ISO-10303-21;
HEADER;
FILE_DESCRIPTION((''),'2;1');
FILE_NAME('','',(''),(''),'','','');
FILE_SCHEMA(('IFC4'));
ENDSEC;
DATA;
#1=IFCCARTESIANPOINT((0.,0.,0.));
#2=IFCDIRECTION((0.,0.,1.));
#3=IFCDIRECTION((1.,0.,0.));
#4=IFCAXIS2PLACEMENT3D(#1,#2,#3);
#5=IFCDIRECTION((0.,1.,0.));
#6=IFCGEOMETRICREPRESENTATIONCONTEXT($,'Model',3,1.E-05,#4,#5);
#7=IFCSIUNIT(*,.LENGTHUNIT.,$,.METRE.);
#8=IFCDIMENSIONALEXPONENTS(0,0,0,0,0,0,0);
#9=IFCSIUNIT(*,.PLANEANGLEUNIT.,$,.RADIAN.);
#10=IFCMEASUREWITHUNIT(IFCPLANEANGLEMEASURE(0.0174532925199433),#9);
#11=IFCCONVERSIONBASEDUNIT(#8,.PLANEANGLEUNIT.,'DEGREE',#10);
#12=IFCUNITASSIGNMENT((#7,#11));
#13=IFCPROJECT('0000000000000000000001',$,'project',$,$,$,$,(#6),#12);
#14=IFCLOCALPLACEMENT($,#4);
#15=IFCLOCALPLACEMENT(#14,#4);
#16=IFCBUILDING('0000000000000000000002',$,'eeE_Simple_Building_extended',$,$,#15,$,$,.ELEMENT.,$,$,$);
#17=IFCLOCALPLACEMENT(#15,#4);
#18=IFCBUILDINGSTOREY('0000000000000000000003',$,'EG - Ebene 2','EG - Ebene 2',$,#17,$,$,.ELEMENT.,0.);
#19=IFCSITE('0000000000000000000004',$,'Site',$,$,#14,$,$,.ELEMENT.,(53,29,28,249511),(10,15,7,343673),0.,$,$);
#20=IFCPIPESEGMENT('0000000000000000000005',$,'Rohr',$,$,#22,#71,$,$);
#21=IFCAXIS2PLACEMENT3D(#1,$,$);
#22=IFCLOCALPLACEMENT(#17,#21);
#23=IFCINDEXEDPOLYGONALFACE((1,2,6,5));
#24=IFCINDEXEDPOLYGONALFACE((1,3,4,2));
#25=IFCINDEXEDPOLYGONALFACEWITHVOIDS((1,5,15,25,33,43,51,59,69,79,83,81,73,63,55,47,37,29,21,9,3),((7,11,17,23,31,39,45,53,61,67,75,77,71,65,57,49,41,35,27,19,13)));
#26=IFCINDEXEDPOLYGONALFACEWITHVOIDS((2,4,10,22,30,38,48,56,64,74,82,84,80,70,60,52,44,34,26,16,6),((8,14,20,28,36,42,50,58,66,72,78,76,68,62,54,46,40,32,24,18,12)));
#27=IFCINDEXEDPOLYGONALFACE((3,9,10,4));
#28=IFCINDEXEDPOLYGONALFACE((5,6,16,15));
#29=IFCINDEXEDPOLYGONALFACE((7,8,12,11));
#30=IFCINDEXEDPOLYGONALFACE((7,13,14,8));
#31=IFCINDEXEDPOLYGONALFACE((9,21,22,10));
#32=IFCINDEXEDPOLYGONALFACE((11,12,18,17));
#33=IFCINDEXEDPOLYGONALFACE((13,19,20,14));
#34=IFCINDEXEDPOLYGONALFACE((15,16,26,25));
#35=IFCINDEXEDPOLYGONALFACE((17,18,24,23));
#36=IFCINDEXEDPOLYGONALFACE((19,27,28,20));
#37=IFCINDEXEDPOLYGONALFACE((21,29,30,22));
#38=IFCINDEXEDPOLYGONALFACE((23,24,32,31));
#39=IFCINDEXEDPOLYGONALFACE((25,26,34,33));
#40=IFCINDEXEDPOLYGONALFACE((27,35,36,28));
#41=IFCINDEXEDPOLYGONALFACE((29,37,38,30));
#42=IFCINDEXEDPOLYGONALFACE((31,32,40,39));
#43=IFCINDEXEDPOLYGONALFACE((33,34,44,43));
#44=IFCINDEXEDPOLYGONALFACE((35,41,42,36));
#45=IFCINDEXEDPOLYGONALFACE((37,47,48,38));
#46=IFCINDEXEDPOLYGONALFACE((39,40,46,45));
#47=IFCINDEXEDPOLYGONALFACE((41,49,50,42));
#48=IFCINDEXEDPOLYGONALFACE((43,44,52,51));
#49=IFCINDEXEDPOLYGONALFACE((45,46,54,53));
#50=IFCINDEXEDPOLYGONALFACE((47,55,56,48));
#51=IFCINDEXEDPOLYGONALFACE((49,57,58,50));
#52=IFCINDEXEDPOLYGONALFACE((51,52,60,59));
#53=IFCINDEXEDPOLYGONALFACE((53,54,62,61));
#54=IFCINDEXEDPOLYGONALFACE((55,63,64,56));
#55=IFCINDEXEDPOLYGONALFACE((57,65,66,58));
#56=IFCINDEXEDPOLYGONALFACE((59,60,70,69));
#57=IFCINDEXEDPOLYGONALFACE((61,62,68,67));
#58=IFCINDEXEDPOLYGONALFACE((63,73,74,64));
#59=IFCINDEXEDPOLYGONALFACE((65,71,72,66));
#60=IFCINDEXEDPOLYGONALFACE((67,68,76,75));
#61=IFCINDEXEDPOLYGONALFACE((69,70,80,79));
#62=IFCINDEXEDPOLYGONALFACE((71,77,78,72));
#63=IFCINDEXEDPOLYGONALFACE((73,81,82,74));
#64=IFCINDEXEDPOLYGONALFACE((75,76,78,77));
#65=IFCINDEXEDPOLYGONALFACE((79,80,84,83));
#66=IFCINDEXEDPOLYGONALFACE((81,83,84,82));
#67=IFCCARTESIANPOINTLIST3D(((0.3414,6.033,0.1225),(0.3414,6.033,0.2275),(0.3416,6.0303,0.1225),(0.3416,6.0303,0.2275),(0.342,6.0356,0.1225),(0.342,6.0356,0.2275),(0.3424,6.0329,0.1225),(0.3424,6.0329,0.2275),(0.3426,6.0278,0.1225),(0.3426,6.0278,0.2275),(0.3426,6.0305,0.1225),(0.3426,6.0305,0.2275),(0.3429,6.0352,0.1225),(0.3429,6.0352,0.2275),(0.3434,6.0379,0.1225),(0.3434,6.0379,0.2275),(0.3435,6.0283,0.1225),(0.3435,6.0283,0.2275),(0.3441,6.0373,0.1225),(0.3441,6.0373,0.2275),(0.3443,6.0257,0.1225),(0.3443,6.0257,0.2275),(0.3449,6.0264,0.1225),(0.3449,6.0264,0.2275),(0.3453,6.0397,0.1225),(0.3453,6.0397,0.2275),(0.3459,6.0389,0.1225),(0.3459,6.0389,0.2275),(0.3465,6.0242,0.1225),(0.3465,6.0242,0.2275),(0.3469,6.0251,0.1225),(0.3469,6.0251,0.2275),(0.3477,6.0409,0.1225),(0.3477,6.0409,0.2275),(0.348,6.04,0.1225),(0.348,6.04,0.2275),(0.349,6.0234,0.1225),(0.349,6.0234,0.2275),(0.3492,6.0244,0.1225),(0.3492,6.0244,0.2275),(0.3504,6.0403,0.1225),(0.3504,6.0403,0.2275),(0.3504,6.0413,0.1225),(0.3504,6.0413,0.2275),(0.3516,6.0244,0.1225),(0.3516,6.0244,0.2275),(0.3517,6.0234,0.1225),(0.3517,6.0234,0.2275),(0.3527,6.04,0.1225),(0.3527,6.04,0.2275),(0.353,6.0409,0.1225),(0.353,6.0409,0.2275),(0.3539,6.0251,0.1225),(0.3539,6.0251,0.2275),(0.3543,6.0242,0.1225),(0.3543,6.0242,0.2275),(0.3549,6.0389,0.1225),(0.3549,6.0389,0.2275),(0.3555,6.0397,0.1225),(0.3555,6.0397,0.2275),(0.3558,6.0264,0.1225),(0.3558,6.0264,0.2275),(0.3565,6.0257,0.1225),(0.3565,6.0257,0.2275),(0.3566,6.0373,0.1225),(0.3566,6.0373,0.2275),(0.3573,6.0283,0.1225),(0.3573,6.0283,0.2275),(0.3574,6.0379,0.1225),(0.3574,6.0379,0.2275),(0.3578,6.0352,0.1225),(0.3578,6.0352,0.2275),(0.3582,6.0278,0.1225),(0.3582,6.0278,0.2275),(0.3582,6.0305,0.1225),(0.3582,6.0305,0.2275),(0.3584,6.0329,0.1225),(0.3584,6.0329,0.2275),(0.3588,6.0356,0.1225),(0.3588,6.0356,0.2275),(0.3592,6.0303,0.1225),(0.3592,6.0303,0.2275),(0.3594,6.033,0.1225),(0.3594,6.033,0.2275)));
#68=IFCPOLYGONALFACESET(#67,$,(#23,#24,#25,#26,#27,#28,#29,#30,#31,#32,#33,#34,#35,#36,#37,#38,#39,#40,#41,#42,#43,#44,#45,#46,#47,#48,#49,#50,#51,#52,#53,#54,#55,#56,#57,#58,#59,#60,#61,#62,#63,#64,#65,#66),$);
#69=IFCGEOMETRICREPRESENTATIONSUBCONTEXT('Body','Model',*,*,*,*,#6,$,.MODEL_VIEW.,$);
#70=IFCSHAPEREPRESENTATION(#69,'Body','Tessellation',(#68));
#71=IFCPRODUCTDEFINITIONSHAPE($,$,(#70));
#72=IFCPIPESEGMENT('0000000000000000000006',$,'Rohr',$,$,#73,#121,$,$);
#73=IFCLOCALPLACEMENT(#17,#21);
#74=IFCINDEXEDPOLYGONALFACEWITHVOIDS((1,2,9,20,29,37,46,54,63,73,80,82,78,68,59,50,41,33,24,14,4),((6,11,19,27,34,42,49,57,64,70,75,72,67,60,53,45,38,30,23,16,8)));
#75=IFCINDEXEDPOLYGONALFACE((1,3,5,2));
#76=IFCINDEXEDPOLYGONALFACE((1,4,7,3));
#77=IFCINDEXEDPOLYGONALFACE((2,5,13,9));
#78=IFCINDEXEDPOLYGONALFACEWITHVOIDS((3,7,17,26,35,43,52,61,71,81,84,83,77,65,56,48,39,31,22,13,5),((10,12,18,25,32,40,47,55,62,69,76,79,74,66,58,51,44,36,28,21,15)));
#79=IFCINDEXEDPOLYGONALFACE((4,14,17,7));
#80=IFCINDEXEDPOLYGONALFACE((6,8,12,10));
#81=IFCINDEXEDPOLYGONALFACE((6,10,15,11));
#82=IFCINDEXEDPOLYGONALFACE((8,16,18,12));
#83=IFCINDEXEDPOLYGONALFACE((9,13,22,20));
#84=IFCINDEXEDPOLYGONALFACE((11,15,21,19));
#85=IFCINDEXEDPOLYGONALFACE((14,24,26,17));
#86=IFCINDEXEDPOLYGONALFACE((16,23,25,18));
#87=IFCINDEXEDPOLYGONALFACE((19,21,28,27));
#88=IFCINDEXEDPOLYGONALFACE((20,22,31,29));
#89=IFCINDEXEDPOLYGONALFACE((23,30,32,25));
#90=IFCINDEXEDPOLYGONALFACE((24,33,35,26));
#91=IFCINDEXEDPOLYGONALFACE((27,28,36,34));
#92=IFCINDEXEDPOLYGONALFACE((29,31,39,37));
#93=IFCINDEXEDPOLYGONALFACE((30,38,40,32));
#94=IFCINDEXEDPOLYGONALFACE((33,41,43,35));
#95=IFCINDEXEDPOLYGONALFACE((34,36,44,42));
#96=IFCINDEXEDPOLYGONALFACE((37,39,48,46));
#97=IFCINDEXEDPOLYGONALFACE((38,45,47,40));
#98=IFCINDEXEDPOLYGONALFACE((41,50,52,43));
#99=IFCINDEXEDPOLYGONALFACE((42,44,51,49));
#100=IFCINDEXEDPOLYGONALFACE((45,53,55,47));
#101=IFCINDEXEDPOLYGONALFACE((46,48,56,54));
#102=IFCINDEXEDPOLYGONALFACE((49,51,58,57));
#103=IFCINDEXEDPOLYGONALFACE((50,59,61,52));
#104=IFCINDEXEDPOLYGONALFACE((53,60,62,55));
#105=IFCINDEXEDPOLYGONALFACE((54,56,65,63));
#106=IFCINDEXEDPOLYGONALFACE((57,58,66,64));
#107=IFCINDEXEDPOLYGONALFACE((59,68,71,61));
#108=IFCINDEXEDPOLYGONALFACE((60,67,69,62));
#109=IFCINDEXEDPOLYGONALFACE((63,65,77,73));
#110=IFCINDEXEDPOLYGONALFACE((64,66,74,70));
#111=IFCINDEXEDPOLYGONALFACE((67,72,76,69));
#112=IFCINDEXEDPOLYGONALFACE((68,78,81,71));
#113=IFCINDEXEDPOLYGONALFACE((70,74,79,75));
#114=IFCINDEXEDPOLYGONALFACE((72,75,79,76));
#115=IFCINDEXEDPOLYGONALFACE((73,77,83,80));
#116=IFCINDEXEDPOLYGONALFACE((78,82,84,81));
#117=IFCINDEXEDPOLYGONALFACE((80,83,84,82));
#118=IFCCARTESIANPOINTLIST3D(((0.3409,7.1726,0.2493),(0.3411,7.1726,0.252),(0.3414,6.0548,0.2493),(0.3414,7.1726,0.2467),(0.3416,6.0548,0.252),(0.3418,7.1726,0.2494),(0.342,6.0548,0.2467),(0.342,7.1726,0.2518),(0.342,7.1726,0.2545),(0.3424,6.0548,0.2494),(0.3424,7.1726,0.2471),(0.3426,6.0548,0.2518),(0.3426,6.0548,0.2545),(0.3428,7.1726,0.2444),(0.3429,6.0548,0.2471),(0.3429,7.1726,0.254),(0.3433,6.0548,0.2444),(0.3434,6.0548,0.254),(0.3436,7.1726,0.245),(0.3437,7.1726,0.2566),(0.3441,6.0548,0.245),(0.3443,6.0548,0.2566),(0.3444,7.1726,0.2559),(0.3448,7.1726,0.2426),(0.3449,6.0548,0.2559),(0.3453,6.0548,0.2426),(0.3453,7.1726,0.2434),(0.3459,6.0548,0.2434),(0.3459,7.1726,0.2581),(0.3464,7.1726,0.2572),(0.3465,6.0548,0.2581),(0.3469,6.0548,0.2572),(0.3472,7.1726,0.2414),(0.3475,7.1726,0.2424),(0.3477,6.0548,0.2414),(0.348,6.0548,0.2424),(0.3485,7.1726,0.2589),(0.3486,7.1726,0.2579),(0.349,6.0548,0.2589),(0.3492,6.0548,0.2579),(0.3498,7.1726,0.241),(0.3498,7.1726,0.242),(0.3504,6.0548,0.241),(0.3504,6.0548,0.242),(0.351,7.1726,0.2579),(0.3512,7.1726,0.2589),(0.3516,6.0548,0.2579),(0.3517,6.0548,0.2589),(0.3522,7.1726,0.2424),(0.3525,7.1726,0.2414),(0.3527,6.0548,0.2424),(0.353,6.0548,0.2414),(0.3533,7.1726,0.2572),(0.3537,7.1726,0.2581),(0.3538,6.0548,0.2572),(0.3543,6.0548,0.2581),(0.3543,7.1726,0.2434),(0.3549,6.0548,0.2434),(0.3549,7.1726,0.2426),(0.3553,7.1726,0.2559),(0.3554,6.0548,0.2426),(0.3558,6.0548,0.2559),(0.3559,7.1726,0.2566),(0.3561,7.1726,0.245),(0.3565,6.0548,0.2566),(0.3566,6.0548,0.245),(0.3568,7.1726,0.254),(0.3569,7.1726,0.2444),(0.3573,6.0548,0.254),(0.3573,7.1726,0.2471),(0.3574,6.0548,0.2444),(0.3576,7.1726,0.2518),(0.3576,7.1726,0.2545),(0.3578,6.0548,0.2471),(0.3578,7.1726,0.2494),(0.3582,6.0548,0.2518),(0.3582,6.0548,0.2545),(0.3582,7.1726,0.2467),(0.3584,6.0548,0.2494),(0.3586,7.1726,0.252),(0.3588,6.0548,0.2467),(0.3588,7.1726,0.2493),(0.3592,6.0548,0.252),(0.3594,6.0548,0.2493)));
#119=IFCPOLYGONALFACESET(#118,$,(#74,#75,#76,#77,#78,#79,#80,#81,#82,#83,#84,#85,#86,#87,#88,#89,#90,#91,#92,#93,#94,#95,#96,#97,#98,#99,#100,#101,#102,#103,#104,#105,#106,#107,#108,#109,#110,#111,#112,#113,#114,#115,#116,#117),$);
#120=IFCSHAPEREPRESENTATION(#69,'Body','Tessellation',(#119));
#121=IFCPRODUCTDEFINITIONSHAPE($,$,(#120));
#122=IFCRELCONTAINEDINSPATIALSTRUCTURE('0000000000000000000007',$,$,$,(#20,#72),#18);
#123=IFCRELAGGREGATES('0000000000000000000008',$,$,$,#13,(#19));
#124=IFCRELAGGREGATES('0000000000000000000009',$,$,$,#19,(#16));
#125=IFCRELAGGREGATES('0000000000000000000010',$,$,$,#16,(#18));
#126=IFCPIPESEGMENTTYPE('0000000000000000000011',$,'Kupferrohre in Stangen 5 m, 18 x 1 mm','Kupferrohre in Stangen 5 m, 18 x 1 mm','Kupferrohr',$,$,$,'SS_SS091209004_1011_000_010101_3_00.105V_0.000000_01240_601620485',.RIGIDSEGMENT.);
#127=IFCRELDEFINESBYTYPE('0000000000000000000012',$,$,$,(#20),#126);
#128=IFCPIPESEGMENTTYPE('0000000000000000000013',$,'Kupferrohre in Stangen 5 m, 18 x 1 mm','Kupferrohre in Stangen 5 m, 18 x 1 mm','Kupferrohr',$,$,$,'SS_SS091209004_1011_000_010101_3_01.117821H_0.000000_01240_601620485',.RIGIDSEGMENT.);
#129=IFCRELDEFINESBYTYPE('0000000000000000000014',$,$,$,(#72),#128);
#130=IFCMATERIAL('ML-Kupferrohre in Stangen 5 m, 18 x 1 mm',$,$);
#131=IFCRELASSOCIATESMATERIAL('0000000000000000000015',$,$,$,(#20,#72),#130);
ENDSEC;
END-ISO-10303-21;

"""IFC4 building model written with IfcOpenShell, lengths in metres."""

from ifc_helpers import new_model, entity, si_unit, converted_unit, direction, frame, origin_with_axes, origin_2d_with_axis, place, context, subcontext, project, spatial, hollow_circle, extrude, material, type_object, element, save


model = new_model("IFC4")

# Units and contexts
model_context = context("Model", 3, precision=1e-05, world=origin_with_axes(), true_north=direction((0.0, 1.0, 0.0)))
body_context = subcontext(model_context, "Body", "Model", "MODEL_VIEW")
ifc_project = project(units=[si_unit("LENGTHUNIT", "METRE"), converted_unit("PLANEANGLEUNIT", "DEGREE", entity("IfcPlaneAngleMeasure", 0.0174532925199433), si_unit("PLANEANGLEUNIT", "RADIAN"), dimensions=[0, 0, 0, 0, 0, 0, 0])], contexts=[model_context])

# Site, building, storey
site_placement = place(None, origin_with_axes())
site = spatial("IfcSite", under=ifc_project, at=site_placement, Name="Site", CompositionType="ELEMENT", RefLatitude=(53, 29, 28, 249511), RefLongitude=(10, 15, 7, 343673), RefElevation=0.0)
building_placement = place(site_placement, origin_with_axes())
building = spatial("IfcBuilding", under=site, at=building_placement, Name="eeE_Simple_Building_extended", CompositionType="ELEMENT")
storey_placement = place(building_placement, origin_with_axes())
storey = spatial("IfcBuildingStorey", under=building, at=storey_placement, Name="EG - Ebene 2", Description="EG - Ebene 2", CompositionType="ELEMENT", Elevation=0.0)

# Pipe segments
ifc_material_1 = material(Name="ML-Kupferrohre in Stangen 5 m, 18 x 1 mm")
pipe_segment_type_1 = type_object("IfcPipeSegmentType", Name="Kupferrohre in Stangen 5 m, 18 x 1 mm", Description="Kupferrohre in Stangen 5 m, 18 x 1 mm", ApplicableOccurrence="Kupferrohr", ElementType="SS_SS091209004_1011_000_010101_3_00.105V_0.000000_01240_601620485", PredefinedType="RIGIDSEGMENT")
pipe_segment_1_placement = place(storey_placement, frame((0.3504, 6.0323, 0.1225), z_axis=(0.0, -1.0, 0.0), x_axis=(0.0, 0.0, 1.0)))
element("IfcPipeSegment", 1, at=pipe_segment_1_placement, inside=storey, type_object=pipe_segment_type_1, material=ifc_material_1, Name="Rohr", context=body_context, shape_type="SweptSolid", body=[
    extrude(hollow_circle(Radius=0.009, WallThickness=0.001, at=origin_2d_with_axis()), frame((0.0, 0.0, 0.0), z_axis=(1.0, 0.0, 0.0), x_axis=(0.0, 0.0, -1.0)), (0.0, 0.0, 1.0), 0.105),
])
pipe_segment_type_2 = type_object("IfcPipeSegmentType", Name="Kupferrohre in Stangen 5 m, 18 x 1 mm", Description="Kupferrohre in Stangen 5 m, 18 x 1 mm", ApplicableOccurrence="Kupferrohr", ElementType="SS_SS091209004_1011_000_010101_3_01.117821H_0.000000_01240_601620485", PredefinedType="RIGIDSEGMENT")
pipe_segment_2_placement = place(storey_placement, frame((0.3504, 6.0548, 0.25), z_axis=(0.0, 0.0, 1.0), x_axis=(-0.000492, 1.0, 0.0)))
element("IfcPipeSegment", 2, at=pipe_segment_2_placement, inside=storey, type_object=pipe_segment_type_2, material=ifc_material_1, Name="Rohr", context=body_context, shape_type="SweptSolid", body=[
    extrude(hollow_circle(Radius=0.009, WallThickness=0.001, at=origin_2d_with_axis()), frame((0.0, 0.0, 0.0), z_axis=(1.0, 0.0, 0.0), x_axis=(0.0, 0.0, -1.0)), (0.0, 0.0, 1.0), 1.1178),
])

save(model, "model.ifc")
